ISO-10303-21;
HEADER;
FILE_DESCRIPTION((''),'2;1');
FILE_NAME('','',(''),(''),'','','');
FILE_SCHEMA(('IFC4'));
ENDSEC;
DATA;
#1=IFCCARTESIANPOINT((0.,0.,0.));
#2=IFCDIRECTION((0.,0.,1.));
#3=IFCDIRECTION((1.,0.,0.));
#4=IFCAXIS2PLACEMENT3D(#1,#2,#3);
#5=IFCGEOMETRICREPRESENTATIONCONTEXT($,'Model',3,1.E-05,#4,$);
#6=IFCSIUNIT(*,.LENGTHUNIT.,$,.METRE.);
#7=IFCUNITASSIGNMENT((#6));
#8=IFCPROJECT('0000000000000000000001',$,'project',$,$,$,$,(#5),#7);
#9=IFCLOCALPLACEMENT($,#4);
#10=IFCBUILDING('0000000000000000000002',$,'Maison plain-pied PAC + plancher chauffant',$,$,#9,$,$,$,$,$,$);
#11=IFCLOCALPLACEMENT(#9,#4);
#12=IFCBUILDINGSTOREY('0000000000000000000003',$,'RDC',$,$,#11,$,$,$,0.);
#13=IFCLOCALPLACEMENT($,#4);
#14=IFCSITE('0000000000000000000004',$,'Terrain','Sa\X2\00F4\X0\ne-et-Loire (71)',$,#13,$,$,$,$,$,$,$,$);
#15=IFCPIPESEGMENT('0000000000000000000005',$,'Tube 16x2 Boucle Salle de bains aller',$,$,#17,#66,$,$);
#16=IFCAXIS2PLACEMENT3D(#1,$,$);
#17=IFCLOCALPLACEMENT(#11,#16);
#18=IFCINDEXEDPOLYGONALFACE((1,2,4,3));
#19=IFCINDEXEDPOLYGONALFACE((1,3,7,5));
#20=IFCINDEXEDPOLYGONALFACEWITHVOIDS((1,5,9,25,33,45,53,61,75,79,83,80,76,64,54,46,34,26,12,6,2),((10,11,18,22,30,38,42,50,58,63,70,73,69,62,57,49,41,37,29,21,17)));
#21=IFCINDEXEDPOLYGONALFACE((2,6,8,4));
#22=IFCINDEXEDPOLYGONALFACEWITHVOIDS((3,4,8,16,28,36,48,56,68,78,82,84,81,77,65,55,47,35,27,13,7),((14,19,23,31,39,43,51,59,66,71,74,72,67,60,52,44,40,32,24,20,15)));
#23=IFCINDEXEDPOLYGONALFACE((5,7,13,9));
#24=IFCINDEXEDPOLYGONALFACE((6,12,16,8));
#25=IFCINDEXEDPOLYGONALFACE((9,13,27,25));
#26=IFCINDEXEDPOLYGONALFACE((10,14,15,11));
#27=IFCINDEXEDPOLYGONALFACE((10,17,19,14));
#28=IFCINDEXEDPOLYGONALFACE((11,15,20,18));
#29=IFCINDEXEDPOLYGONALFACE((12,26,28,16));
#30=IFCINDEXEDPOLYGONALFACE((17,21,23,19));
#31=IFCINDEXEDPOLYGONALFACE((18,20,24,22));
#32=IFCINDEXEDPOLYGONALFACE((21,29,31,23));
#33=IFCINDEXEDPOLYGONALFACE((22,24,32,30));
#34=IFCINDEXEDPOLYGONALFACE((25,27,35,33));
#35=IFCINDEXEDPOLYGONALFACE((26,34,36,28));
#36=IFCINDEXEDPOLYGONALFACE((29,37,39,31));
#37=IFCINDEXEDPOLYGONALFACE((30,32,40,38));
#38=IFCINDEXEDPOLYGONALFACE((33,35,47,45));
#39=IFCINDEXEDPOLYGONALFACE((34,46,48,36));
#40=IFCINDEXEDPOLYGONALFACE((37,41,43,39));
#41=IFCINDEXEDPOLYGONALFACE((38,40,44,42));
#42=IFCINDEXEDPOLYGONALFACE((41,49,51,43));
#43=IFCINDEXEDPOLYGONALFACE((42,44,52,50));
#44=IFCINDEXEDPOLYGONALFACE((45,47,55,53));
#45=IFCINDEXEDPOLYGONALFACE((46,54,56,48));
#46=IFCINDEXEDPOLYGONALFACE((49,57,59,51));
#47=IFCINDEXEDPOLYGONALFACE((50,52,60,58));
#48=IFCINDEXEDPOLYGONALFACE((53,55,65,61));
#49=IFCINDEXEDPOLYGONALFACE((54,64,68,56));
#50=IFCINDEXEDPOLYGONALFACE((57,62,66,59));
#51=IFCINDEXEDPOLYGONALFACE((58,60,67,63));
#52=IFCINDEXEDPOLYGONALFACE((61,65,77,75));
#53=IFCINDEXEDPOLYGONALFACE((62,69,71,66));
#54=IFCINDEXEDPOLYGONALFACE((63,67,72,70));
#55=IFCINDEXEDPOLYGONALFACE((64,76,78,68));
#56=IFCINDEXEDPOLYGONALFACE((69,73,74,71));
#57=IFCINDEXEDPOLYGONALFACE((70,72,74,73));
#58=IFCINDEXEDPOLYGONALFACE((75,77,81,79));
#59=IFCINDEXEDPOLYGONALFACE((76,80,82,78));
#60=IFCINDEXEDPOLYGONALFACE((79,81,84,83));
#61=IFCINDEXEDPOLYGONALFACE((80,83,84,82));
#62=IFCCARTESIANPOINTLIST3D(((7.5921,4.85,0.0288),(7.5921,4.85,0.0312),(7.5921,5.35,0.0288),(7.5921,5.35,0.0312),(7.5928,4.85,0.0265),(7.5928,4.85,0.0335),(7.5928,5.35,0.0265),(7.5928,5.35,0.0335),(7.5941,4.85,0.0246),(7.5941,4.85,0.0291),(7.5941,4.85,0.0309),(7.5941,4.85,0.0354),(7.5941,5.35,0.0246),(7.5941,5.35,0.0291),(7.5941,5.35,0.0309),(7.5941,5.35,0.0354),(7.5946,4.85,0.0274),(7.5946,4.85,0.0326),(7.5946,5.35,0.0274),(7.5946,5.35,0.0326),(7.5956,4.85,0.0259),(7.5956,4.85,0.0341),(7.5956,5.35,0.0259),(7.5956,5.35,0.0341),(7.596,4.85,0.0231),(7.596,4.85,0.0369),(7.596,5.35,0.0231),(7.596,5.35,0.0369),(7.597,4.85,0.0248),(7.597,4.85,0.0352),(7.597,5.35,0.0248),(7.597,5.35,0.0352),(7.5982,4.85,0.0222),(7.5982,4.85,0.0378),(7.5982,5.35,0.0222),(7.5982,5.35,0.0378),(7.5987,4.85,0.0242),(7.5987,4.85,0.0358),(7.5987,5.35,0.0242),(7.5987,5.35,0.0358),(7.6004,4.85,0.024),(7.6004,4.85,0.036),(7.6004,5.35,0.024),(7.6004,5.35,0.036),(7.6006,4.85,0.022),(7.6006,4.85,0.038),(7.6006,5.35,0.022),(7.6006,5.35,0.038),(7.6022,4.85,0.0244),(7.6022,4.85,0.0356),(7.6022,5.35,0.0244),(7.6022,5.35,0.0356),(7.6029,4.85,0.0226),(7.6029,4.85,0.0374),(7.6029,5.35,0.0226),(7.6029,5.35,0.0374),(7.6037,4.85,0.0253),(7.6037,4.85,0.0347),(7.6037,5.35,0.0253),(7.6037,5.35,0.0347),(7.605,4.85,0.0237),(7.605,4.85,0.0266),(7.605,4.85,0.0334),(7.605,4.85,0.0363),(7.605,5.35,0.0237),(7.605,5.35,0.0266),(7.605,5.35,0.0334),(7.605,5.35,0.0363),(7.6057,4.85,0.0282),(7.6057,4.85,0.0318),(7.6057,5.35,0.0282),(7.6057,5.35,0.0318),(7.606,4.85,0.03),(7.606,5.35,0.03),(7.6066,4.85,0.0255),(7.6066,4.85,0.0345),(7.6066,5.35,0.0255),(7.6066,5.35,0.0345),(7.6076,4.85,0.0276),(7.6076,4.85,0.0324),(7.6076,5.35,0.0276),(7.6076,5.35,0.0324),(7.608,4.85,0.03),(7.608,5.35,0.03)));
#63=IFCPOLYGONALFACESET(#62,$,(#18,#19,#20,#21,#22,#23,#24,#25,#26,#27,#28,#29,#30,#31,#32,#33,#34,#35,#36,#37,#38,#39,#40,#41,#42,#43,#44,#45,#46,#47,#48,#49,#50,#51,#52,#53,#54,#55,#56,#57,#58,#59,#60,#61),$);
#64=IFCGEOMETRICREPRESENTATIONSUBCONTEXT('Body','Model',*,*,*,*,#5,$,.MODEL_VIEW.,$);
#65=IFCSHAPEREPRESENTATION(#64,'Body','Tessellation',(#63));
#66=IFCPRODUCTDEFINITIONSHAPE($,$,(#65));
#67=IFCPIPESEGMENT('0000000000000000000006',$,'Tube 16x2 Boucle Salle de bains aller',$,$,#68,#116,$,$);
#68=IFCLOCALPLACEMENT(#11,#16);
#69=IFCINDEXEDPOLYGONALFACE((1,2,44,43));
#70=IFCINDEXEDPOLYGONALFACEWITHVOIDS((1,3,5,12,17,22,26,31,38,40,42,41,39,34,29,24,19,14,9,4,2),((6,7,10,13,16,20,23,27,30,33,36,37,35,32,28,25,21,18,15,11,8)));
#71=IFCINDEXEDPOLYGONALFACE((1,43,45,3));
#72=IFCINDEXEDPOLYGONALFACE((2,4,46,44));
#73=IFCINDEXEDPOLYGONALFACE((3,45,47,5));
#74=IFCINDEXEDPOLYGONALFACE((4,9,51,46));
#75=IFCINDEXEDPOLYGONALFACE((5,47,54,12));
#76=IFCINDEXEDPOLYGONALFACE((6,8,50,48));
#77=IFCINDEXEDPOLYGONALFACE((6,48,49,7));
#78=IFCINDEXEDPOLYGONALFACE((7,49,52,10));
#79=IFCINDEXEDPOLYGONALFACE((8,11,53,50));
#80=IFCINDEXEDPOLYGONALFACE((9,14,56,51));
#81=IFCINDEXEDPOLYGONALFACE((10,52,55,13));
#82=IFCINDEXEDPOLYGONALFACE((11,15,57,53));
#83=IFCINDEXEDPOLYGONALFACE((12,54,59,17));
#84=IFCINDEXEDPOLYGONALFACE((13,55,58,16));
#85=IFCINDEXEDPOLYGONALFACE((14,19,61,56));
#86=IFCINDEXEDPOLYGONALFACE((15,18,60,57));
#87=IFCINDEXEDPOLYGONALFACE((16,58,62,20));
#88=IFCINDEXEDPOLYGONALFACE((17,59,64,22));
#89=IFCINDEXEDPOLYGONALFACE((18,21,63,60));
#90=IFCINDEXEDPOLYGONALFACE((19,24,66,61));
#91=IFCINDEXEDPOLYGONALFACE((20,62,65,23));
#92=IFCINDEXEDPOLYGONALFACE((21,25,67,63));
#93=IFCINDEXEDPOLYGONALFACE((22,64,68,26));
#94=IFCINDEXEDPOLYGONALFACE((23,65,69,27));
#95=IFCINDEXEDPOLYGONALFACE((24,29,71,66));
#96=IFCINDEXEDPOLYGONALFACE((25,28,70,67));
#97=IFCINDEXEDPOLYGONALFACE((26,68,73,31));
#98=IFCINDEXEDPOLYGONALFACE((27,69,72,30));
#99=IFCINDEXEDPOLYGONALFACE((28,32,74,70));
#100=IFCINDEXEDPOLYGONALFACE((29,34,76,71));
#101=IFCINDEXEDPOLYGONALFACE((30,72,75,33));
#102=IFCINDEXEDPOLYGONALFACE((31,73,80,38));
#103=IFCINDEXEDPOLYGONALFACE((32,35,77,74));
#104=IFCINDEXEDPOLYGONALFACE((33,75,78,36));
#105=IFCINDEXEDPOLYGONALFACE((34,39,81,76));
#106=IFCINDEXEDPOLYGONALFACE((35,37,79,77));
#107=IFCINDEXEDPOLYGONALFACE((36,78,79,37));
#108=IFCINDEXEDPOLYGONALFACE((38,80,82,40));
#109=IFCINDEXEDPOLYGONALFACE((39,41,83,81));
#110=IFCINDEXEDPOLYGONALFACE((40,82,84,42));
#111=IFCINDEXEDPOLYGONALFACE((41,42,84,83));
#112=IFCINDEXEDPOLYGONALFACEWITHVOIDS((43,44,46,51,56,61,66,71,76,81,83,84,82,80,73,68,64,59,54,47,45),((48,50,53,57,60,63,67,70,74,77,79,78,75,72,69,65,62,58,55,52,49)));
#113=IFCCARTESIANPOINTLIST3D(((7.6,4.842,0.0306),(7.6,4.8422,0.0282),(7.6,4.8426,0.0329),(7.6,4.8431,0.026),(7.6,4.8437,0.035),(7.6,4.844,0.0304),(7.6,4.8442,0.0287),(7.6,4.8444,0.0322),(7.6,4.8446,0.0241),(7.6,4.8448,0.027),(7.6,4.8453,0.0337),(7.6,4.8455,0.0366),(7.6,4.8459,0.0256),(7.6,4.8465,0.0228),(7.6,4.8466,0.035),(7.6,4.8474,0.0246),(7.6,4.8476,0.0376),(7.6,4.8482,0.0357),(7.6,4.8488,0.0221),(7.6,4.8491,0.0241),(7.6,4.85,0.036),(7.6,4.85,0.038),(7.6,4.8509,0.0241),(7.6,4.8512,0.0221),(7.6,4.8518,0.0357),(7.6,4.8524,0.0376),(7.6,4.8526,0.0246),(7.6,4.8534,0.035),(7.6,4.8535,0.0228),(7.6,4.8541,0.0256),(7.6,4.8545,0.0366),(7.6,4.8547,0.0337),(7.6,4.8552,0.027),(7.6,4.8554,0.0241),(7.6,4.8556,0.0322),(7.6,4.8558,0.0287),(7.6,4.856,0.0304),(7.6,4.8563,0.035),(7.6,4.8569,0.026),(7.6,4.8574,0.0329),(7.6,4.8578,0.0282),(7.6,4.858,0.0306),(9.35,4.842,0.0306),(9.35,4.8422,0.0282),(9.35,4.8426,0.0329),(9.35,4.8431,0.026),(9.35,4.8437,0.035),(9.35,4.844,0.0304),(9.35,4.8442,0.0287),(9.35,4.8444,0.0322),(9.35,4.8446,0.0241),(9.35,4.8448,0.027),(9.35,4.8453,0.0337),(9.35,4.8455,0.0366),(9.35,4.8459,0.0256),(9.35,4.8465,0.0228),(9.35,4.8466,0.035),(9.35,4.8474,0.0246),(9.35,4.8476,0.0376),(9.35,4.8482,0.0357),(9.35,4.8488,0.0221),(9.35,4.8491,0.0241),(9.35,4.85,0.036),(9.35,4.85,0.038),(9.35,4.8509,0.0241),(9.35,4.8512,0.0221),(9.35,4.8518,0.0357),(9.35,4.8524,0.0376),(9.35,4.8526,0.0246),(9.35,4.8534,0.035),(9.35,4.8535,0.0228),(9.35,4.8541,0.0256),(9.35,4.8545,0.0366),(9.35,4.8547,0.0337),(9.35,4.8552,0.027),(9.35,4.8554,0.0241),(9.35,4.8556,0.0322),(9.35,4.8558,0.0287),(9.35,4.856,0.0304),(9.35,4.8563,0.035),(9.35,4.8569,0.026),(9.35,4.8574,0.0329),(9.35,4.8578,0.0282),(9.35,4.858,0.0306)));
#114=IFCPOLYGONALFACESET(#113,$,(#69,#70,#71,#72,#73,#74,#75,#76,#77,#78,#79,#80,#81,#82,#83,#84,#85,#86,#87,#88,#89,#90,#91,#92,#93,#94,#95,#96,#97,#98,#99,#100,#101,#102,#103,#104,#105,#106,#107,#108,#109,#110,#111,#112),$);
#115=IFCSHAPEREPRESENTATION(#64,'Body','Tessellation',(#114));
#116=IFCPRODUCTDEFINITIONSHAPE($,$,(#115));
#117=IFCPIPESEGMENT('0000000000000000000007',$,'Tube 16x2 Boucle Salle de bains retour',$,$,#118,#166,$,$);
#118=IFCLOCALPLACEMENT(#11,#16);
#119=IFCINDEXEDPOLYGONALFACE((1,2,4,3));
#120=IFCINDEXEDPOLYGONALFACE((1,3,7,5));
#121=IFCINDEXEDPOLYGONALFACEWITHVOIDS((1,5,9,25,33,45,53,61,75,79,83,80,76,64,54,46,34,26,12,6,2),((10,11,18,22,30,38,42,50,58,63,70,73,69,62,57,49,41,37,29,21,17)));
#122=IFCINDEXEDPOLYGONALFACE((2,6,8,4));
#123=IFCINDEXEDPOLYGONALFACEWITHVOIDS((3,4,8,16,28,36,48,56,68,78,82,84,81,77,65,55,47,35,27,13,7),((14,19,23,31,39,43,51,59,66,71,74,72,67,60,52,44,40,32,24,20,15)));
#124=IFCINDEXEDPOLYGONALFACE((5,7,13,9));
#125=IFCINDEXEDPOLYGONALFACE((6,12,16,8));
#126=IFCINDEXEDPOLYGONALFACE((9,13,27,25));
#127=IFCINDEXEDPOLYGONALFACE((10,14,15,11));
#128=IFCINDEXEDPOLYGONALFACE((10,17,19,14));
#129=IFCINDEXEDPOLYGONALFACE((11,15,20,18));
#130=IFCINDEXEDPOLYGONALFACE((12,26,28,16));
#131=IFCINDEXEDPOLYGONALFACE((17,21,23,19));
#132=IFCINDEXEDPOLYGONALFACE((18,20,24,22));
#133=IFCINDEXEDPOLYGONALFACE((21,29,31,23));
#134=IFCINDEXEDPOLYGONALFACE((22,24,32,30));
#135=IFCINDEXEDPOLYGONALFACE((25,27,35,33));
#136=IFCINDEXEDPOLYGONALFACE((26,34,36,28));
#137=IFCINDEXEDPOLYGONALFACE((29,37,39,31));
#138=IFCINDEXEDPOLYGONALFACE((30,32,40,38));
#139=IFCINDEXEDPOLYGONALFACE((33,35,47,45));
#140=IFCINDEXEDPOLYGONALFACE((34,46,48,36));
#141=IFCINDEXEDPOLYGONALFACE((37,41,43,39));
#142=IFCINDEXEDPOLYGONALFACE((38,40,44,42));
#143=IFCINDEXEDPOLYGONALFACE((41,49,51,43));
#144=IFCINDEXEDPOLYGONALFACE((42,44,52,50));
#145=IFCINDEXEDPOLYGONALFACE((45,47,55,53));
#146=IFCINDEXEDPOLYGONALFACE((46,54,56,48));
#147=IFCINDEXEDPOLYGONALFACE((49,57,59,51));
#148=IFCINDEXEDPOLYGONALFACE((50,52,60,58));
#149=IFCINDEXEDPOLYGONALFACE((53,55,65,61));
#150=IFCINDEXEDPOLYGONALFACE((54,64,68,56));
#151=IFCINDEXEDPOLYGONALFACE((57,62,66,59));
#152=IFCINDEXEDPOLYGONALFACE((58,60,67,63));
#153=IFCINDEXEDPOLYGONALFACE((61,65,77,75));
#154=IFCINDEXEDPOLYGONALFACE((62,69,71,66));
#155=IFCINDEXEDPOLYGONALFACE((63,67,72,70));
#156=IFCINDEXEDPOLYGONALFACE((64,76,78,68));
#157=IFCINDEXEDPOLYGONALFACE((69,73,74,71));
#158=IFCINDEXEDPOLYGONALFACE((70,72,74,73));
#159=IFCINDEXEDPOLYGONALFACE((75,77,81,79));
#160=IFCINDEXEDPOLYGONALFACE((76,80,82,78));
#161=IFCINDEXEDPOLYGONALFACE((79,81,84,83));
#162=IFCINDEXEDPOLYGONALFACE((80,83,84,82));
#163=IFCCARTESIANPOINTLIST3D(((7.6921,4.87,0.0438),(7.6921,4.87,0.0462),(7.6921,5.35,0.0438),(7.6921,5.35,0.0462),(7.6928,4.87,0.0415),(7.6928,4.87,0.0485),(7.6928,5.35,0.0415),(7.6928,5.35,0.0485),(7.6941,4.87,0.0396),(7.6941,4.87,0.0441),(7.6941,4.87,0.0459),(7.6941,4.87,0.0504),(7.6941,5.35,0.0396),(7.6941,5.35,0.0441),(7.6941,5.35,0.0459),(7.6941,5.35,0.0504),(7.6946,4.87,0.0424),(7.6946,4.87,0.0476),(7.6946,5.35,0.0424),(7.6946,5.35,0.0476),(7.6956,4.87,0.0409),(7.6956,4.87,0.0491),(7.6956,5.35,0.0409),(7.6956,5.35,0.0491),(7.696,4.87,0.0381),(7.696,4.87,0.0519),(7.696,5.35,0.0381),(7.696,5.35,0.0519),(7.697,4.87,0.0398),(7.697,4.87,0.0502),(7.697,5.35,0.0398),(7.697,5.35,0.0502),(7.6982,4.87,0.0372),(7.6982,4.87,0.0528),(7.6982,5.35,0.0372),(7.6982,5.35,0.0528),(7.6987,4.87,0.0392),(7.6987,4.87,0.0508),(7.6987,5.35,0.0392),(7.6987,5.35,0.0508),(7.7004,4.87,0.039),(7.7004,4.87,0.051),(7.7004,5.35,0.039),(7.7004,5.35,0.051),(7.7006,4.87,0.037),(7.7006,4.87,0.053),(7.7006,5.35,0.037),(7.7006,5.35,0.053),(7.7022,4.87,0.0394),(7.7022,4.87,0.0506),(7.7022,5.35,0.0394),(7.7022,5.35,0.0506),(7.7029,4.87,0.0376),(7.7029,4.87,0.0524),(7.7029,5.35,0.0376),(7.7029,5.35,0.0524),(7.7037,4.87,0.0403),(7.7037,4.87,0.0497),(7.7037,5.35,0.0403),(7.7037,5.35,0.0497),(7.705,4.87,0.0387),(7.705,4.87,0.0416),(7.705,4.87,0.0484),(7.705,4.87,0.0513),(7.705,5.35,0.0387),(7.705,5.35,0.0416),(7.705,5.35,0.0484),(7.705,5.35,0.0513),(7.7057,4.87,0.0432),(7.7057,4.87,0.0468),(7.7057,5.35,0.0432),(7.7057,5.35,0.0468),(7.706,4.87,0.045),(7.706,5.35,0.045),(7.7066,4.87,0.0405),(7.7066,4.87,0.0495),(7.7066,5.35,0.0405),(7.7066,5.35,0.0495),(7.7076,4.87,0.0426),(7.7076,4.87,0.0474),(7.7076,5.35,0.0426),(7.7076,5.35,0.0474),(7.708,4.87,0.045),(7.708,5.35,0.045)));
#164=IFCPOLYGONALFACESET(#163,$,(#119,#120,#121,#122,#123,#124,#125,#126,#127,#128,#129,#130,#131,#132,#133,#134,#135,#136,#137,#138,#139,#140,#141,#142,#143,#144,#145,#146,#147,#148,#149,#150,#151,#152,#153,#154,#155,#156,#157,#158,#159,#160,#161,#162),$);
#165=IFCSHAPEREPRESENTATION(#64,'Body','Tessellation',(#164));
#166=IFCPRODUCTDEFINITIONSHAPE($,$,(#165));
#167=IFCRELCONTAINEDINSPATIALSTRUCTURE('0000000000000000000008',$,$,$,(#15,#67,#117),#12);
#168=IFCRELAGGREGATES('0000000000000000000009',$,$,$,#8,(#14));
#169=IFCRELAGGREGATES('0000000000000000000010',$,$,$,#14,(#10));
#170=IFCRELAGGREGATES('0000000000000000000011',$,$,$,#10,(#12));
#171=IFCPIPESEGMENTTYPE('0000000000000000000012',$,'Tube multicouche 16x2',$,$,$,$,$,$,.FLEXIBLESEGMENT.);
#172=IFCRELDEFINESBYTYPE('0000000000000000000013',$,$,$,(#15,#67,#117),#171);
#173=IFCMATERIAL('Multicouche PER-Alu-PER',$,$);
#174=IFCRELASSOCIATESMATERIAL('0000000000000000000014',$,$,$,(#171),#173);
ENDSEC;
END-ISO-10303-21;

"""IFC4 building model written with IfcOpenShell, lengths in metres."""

from ifc_helpers import new_model, si_unit, frame, origin_with_axes, place, context, subcontext, project, spatial, hollow_circle, extrude, material, type_object, element, save


model = new_model("IFC4")

# Units and contexts
model_context = context("Model", 3, precision=1e-05, world=origin_with_axes())
body_context = subcontext(model_context, "Body", "Model", "MODEL_VIEW")
ifc_project = project(units=[si_unit("LENGTHUNIT", "METRE")], contexts=[model_context])

# Site, building, storey
site_placement = place(None, origin_with_axes())
site = spatial("IfcSite", under=ifc_project, at=site_placement, Name="Terrain", Description="Saône-et-Loire (71)")
building_placement = place(None, origin_with_axes())
building = spatial("IfcBuilding", under=site, at=building_placement, Name="Maison plain-pied PAC + plancher chauffant")
storey_placement = place(building_placement, origin_with_axes())
storey = spatial("IfcBuildingStorey", under=building, at=storey_placement, Name="RDC", Elevation=0.0)

# Pipe segments
ifc_material_1 = material(Name="Multicouche PER-Alu-PER")
pipe_segment_type_1 = type_object("IfcPipeSegmentType", Name="Tube multicouche 16x2", PredefinedType="FLEXIBLESEGMENT", material=ifc_material_1)
pipe_segment_1_placement = place(storey_placement, frame((7.6, 5.35, 0.03), z_axis=(0.0, -1.0, 0.0), x_axis=(1.0, 0.0, 0.0)))
element("IfcPipeSegment", 1, at=pipe_segment_1_placement, inside=storey, type_object=pipe_segment_type_1, Name="Tube 16x2 Boucle Salle de bains aller", context=body_context, shape_type="SweptSolid", body=[
    extrude(hollow_circle(Radius=0.008, WallThickness=0.002), origin_with_axes(), (0.0, 0.0, 1.0), 0.5),
])
pipe_segment_2_placement = place(storey_placement, frame((7.6, 4.85, 0.03), z_axis=(1.0, 0.0, 0.0), x_axis=(0.0, 0.0, 1.0)))
element("IfcPipeSegment", 2, at=pipe_segment_2_placement, inside=storey, type_object=pipe_segment_type_1, Name="Tube 16x2 Boucle Salle de bains aller", context=body_context, shape_type="SweptSolid", body=[
    extrude(hollow_circle(Radius=0.008, WallThickness=0.002), origin_with_axes(), (0.0, 0.0, 1.0), 1.75),
])
pipe_segment_3_placement = place(storey_placement, frame((7.7, 4.87, 0.045), z_axis=(0.0, 1.0, 0.0), x_axis=(1.0, 0.0, 0.0)))
element("IfcPipeSegment", 3, at=pipe_segment_3_placement, inside=storey, type_object=pipe_segment_type_1, Name="Tube 16x2 Boucle Salle de bains retour", context=body_context, shape_type="SweptSolid", body=[
    extrude(hollow_circle(Radius=0.008, WallThickness=0.002), origin_with_axes(), (0.0, 0.0, 1.0), 0.48),
])

save(model, "model.ifc")
